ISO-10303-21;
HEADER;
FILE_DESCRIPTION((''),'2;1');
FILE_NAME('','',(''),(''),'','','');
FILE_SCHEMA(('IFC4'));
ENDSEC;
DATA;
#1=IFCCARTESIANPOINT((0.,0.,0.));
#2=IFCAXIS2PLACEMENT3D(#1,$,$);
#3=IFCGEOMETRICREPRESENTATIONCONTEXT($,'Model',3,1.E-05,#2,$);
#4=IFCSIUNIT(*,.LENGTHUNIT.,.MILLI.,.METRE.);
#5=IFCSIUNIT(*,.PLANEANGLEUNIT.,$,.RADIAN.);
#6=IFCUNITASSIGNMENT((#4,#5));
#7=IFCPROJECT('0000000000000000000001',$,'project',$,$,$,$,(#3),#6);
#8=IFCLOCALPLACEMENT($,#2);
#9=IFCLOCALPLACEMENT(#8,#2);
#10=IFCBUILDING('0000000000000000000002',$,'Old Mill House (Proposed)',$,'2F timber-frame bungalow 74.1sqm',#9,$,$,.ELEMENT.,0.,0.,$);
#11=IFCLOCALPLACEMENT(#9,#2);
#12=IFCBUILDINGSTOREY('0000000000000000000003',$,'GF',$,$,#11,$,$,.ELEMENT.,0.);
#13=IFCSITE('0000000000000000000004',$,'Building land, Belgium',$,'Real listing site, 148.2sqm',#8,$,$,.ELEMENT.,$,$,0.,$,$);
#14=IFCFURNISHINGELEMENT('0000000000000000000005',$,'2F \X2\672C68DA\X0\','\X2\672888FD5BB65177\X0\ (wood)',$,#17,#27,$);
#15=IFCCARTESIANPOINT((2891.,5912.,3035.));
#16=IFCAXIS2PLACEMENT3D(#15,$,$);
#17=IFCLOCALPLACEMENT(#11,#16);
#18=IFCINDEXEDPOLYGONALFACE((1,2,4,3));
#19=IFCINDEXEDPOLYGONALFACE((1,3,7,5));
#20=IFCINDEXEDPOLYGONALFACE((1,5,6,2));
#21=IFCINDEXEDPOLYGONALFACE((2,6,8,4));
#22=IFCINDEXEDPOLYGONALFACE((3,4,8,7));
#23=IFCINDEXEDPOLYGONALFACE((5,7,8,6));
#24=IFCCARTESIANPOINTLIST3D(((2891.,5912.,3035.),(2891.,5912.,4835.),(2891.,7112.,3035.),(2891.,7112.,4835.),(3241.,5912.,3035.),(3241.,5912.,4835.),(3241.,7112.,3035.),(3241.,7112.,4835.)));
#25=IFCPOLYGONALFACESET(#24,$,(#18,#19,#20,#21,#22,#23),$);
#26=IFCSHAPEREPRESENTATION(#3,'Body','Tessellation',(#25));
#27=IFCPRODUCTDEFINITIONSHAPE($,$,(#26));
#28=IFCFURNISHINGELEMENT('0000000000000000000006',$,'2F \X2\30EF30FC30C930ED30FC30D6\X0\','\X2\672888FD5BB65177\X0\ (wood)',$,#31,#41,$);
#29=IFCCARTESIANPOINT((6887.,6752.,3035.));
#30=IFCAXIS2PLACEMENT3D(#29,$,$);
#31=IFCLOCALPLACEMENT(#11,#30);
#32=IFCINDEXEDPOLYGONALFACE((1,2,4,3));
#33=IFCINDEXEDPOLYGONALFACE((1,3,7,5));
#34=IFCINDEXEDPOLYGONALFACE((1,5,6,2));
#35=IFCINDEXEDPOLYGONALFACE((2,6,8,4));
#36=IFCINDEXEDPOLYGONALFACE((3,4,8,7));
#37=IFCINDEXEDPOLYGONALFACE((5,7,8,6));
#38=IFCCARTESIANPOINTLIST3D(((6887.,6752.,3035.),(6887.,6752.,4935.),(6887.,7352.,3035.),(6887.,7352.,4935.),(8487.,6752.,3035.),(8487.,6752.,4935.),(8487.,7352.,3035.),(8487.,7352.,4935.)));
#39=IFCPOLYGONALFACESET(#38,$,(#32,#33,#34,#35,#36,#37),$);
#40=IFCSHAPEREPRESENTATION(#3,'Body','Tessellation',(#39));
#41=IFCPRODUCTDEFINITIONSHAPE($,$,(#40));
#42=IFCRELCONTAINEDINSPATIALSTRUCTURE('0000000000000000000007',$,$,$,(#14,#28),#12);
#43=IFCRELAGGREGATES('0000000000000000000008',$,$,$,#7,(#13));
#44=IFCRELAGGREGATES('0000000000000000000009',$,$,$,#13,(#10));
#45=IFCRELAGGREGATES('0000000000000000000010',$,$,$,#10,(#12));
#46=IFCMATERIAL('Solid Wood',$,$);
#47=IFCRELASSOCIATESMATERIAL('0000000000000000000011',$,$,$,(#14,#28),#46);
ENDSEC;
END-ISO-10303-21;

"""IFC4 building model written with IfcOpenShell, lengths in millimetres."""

from ifc_helpers import new_model, si_unit, frame, frame_2d, origin, place, context, project, spatial, rectangle, extrude, material, element, save


model = new_model("IFC4")

# Units and contexts
model_context = context("Model", 3, precision=1e-05, world=origin())
ifc_project = project(units=[si_unit("LENGTHUNIT", "METRE", prefix="MILLI"), si_unit("PLANEANGLEUNIT", "RADIAN")], contexts=[model_context])

# Site, building, storey
site_placement = place(None, origin())
site = spatial("IfcSite", under=ifc_project, at=site_placement, Name="Building land, Belgium", ObjectType="Real listing site, 148.2sqm", CompositionType="ELEMENT", RefElevation=0.0)
building_placement = place(site_placement, origin())
building = spatial("IfcBuilding", under=site, at=building_placement, Name="Old Mill House (Proposed)", ObjectType="2F timber-frame bungalow 74.1sqm", CompositionType="ELEMENT", ElevationOfRefHeight=0.0, ElevationOfTerrain=0.0)
storey_placement = place(building_placement, origin())
storey = spatial("IfcBuildingStorey", under=building, at=storey_placement, Name="GF", CompositionType="ELEMENT", Elevation=0.0)

# Shared definitions
ifc_material_1 = material(Name="Solid Wood")

# Furnishing elements
furnishing_1_placement = place(storey_placement, frame((2891.0, 5912.0, 3035.0)))
element("IfcFurnishingElement", 1, at=furnishing_1_placement, inside=storey, material=ifc_material_1, Name="2F 本棚", Description="木製家具 (wood)", context=model_context, shape_type="SweptSolid", body=[
    extrude(rectangle(XDim=350.0, YDim=1200.0, at=frame_2d((175.0, 600.0))), frame((2891.0, 5912.0, 3035.0)), (0.0, 0.0, 1.0), 1800.0),
])
furnishing_2_placement = place(storey_placement, frame((6887.0, 6752.0, 3035.0)))
element("IfcFurnishingElement", 2, at=furnishing_2_placement, inside=storey, material=ifc_material_1, Name="2F ワードローブ", Description="木製家具 (wood)", context=model_context, shape_type="SweptSolid", body=[
    extrude(rectangle(XDim=1600.0, YDim=600.0, at=frame_2d((800.0, 300.0))), frame((6887.0, 6752.0, 3035.0)), (0.0, 0.0, 1.0), 1900.0),
])

save(model, "model.ifc")
